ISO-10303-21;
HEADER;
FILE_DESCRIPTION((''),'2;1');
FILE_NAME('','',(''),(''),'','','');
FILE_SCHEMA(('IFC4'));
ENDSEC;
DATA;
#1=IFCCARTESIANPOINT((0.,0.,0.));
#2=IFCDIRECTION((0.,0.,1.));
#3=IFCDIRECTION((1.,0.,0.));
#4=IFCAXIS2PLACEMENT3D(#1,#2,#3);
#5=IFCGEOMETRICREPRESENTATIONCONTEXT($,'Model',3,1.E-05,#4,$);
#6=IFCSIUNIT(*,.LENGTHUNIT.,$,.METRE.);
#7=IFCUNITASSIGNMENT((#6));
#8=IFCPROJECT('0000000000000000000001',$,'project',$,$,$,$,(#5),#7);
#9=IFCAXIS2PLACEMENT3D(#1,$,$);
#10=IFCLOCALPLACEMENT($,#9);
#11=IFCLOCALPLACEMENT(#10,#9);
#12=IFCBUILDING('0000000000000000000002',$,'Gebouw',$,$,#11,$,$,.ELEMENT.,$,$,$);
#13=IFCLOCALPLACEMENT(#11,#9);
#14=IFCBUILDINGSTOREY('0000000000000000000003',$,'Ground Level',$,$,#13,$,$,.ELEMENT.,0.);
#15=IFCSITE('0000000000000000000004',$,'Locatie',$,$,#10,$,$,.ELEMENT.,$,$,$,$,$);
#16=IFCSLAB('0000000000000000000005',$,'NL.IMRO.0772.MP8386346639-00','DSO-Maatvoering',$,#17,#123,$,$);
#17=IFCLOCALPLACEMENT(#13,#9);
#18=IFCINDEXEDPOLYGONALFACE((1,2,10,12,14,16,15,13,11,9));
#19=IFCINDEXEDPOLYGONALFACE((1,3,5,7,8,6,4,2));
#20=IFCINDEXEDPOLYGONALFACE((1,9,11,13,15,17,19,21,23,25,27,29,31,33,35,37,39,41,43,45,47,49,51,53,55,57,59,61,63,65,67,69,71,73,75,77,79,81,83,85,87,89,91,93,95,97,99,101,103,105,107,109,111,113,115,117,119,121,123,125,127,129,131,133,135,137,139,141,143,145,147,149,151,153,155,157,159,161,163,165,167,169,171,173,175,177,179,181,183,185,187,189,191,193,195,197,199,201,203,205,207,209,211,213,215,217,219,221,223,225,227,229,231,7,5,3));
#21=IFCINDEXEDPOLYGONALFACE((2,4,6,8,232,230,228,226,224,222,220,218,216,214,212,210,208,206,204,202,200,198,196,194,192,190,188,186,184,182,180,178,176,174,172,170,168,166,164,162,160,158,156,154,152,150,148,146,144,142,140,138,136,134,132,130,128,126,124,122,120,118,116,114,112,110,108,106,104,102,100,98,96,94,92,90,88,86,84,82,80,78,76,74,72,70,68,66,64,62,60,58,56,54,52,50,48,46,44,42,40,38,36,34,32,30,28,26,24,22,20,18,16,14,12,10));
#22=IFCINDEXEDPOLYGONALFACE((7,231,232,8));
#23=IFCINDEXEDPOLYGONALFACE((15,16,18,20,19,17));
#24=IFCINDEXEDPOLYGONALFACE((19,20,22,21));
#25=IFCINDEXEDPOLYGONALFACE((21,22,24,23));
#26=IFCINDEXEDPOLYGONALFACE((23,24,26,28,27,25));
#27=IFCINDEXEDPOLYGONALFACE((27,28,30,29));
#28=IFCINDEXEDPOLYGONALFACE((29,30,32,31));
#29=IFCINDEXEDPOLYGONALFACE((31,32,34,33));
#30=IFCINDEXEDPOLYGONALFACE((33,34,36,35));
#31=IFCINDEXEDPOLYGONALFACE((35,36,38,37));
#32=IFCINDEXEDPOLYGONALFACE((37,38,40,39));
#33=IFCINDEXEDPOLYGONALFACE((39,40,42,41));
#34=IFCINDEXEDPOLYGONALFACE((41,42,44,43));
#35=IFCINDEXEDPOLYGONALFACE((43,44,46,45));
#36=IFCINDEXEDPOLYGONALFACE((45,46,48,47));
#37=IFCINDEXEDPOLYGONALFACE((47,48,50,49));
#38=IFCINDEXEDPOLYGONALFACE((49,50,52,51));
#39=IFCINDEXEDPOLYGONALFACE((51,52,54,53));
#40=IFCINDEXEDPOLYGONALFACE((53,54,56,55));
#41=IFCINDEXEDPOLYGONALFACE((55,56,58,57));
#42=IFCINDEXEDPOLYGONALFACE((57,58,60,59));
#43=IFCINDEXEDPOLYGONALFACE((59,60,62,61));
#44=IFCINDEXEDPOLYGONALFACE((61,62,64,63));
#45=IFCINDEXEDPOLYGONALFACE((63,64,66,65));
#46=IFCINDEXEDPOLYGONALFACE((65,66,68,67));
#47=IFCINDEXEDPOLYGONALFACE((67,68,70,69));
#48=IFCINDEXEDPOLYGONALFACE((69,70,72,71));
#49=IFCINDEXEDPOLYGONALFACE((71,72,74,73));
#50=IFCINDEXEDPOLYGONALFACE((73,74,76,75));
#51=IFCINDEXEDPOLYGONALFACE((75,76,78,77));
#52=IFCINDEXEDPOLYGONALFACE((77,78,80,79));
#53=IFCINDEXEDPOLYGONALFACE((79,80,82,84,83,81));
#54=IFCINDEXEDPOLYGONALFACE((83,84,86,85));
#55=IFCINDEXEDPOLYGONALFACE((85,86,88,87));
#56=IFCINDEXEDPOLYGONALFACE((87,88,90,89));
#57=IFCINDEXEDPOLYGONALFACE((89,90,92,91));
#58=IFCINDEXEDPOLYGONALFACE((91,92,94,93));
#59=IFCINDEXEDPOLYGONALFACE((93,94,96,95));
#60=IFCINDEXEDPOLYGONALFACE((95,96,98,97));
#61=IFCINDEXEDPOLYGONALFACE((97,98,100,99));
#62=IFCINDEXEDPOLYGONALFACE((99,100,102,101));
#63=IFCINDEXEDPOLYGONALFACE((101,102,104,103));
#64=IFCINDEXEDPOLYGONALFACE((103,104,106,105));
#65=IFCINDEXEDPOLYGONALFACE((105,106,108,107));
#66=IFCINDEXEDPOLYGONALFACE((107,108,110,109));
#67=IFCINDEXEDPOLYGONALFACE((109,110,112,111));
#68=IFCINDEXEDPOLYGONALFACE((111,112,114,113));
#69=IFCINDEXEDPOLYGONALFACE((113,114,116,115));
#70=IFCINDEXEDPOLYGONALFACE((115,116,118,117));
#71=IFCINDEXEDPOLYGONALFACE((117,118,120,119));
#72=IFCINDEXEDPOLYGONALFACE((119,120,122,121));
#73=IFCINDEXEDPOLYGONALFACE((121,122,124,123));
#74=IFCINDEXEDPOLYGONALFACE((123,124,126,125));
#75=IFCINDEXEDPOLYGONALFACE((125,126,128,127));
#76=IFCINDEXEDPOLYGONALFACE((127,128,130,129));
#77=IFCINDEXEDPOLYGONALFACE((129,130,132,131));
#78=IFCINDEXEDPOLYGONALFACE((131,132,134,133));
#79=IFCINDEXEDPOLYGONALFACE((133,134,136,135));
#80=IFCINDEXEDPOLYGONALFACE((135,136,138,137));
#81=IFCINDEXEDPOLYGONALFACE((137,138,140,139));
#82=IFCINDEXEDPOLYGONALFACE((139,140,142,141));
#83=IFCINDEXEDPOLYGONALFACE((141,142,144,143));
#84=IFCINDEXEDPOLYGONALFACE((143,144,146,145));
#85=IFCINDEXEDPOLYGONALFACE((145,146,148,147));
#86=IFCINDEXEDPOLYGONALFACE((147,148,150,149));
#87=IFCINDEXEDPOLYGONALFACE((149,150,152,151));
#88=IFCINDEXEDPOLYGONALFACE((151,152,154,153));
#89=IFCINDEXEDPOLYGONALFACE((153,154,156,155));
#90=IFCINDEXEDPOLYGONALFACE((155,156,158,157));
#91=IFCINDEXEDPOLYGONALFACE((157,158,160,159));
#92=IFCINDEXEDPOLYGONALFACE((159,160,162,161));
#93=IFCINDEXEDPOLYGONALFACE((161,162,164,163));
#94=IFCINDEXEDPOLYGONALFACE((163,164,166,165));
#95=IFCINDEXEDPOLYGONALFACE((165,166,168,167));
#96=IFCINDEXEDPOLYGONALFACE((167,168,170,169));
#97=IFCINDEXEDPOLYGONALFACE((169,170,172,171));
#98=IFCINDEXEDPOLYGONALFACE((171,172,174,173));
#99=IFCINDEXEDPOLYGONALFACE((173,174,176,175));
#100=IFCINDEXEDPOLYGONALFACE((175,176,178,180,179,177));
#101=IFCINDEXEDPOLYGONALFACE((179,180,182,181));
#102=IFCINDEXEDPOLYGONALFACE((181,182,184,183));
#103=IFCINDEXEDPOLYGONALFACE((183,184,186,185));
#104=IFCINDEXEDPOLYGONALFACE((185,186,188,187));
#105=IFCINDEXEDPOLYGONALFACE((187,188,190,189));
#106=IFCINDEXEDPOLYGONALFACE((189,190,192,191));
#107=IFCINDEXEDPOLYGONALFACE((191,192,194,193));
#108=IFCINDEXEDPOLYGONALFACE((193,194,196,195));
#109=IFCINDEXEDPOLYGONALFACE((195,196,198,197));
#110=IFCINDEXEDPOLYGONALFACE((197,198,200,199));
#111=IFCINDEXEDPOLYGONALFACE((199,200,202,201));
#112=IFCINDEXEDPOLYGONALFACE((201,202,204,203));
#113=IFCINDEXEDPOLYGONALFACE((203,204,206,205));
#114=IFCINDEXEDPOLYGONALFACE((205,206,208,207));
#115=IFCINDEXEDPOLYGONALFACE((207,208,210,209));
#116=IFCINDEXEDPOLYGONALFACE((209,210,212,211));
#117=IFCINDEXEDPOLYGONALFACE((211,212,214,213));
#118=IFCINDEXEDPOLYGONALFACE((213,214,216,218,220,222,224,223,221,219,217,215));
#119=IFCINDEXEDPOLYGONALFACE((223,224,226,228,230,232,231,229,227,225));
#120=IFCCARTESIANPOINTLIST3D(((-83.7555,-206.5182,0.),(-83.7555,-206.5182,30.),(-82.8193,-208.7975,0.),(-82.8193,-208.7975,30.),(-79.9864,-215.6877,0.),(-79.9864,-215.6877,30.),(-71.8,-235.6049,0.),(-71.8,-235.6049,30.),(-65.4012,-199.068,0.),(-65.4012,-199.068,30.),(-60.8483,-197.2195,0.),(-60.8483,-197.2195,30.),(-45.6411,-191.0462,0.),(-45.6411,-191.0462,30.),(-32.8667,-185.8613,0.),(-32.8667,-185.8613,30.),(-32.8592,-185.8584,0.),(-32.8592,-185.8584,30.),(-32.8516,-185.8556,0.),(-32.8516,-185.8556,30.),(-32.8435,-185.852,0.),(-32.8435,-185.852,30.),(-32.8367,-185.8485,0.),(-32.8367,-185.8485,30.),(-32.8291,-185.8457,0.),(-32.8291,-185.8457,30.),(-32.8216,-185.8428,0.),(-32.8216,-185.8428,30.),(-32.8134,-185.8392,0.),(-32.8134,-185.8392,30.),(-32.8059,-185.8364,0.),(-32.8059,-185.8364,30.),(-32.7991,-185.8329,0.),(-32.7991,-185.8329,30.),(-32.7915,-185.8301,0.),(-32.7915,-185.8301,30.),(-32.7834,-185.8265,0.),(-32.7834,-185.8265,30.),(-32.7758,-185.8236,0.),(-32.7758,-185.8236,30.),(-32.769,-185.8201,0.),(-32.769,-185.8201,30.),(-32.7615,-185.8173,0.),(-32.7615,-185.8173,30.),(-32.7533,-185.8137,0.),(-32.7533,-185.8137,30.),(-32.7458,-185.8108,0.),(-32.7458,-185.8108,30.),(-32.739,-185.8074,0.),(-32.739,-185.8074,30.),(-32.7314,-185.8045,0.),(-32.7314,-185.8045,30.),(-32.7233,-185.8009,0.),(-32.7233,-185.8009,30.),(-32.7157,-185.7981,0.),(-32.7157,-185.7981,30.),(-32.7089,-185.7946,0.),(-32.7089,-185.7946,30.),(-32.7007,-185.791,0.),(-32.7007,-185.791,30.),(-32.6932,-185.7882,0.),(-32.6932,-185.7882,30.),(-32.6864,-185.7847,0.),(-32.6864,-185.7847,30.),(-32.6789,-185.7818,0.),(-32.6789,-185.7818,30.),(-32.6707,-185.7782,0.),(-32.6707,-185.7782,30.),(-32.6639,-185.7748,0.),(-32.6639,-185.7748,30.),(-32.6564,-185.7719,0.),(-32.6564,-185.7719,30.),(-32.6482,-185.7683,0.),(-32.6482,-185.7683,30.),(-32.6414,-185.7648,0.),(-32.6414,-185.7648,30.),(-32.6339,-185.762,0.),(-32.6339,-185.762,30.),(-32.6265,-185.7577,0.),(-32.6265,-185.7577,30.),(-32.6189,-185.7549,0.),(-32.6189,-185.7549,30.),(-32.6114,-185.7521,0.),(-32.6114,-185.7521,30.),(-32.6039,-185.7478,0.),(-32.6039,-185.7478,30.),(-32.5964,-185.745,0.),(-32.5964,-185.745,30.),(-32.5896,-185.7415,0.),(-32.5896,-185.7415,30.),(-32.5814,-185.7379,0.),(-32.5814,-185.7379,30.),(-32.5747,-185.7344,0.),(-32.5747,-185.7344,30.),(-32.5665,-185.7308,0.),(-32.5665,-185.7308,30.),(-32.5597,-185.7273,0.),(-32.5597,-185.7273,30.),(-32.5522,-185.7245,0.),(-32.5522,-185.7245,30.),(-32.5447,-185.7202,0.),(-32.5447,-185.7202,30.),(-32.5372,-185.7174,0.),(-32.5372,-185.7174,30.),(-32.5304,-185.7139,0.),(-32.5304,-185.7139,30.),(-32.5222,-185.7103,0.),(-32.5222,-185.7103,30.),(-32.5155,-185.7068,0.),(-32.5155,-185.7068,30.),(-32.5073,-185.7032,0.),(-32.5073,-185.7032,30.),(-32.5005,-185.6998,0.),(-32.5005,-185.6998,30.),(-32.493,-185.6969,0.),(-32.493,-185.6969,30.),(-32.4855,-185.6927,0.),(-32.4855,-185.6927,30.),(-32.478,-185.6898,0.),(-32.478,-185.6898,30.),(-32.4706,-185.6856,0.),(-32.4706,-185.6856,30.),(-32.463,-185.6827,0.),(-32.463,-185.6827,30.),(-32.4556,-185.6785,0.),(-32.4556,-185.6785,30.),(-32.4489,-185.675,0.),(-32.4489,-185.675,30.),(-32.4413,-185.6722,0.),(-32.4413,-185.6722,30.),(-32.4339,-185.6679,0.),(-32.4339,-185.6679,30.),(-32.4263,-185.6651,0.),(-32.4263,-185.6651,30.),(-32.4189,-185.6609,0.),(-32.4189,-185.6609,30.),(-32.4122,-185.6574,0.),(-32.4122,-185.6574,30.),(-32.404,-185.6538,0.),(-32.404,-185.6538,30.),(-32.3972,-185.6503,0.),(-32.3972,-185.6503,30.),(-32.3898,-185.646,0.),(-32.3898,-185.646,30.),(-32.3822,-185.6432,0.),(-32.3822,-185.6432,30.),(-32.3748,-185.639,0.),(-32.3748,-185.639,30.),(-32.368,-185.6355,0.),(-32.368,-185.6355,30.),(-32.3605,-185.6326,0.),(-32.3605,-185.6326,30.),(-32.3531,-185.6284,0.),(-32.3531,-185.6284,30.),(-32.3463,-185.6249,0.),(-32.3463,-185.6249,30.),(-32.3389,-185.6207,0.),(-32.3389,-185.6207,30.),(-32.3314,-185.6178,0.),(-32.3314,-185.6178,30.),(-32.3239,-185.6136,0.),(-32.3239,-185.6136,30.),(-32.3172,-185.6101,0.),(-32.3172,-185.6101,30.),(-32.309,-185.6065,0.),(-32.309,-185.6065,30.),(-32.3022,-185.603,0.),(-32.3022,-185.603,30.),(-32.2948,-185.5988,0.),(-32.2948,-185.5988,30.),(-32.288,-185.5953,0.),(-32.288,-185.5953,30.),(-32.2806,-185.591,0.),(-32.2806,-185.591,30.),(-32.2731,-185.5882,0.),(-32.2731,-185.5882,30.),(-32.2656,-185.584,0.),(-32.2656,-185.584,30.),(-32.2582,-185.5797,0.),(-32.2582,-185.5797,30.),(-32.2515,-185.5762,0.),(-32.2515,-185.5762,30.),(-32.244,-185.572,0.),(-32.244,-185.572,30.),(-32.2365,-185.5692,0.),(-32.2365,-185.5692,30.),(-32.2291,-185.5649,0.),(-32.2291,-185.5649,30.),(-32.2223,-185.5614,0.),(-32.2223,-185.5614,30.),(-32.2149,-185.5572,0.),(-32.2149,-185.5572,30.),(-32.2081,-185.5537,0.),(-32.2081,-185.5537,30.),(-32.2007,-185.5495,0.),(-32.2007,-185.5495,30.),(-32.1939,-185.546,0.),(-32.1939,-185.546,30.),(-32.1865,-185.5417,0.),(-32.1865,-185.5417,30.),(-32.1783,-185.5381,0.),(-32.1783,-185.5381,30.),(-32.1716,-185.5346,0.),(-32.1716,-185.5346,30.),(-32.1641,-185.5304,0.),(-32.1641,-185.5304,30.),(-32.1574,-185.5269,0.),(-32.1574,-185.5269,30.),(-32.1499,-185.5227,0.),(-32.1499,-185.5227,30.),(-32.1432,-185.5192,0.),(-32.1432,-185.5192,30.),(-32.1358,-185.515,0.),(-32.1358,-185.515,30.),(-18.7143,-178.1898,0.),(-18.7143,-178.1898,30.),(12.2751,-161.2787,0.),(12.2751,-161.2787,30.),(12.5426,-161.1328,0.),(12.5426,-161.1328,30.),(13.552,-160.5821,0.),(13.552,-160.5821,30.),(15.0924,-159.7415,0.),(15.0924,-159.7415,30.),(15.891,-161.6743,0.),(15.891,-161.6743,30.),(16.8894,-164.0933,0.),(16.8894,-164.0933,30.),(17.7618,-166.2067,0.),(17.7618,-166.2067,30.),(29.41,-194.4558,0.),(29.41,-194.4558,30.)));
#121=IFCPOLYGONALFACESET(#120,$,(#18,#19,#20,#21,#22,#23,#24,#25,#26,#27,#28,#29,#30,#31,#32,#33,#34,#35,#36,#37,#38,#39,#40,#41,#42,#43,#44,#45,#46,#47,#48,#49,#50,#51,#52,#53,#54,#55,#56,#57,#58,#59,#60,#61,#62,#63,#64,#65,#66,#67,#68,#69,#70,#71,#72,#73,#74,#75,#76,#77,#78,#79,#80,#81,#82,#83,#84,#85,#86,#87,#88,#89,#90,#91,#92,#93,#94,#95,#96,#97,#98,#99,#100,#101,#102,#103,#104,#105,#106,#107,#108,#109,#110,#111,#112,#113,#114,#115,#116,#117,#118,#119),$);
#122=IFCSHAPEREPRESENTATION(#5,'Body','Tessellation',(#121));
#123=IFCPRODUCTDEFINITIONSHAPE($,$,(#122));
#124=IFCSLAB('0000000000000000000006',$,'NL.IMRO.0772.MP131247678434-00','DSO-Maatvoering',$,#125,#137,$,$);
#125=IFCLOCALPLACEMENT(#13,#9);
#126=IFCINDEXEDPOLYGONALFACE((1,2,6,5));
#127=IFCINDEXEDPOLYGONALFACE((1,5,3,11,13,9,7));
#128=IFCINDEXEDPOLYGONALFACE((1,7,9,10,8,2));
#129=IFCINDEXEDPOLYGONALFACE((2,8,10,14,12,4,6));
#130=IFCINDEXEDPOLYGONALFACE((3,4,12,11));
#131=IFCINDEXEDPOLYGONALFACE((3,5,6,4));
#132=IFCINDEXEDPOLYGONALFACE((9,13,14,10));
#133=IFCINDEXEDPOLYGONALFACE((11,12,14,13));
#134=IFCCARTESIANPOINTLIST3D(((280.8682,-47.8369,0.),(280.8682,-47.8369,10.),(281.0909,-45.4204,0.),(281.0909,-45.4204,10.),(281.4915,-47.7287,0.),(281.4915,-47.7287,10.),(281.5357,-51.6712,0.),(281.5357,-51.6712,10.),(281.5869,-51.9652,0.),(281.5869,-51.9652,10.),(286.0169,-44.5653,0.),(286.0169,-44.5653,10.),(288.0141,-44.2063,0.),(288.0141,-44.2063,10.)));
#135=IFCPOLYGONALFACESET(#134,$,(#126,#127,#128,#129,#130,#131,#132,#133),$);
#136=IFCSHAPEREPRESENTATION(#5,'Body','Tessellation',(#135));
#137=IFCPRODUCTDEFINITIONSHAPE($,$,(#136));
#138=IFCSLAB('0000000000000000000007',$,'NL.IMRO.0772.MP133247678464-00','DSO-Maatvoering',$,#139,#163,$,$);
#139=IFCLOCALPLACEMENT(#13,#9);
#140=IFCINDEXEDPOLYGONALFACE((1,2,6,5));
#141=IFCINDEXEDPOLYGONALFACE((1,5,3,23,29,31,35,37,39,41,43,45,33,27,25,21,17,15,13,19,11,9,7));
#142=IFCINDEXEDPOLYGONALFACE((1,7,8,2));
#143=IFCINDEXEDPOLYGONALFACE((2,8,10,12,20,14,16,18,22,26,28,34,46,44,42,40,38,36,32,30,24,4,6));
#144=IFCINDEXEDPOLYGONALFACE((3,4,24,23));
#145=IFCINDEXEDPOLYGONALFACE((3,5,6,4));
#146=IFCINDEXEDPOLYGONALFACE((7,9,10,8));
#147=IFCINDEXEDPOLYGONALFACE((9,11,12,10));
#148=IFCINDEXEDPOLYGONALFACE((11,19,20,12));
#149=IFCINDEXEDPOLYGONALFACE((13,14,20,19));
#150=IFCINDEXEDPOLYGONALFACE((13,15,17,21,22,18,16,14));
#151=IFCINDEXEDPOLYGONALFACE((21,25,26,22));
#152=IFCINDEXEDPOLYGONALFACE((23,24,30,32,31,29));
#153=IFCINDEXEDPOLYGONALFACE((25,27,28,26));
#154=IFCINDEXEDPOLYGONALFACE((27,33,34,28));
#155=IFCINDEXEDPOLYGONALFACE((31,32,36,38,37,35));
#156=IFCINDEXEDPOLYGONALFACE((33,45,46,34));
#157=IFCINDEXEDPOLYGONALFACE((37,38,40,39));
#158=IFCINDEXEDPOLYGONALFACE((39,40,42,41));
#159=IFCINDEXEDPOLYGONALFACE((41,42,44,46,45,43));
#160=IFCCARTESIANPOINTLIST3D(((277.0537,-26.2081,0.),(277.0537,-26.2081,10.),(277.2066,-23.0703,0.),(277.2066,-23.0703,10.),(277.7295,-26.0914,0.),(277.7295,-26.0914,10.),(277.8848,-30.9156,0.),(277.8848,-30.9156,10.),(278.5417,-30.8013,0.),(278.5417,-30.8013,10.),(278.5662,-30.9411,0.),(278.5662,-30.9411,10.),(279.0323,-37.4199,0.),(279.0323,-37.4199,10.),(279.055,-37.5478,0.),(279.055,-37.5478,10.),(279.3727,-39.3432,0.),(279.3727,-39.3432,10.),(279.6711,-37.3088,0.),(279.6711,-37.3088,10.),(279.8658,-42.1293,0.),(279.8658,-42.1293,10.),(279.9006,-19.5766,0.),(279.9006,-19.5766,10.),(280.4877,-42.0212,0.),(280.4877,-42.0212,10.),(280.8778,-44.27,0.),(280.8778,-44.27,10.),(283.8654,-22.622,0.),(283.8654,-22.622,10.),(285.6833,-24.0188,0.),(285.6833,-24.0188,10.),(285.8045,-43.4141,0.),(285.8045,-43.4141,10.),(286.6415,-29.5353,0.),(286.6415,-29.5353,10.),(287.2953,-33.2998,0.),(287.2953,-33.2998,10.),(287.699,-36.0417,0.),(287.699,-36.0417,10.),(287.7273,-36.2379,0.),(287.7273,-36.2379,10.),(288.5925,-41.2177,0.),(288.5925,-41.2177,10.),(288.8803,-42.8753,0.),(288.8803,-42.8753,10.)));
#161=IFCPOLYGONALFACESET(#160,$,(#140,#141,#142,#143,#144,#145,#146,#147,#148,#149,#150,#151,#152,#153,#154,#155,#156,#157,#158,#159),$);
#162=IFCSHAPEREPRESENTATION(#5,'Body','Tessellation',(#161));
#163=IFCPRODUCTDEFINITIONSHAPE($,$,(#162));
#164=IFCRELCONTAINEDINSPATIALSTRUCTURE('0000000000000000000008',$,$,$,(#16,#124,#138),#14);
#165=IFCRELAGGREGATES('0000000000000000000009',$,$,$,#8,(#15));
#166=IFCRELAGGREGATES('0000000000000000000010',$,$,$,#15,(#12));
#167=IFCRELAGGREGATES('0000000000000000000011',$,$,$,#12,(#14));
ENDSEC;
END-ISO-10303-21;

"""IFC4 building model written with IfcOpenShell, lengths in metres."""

from ifc_helpers import new_model, si_unit, origin, origin_with_axes, place, context, project, spatial, polyline, outline, extrude, element, save


model = new_model("IFC4")

# Units and contexts
model_context = context("Model", 3, precision=1e-05, world=origin_with_axes())
ifc_project = project(units=[si_unit("LENGTHUNIT", "METRE")], contexts=[model_context])

# Site, building, storey
site_placement = place(None, origin())
site = spatial("IfcSite", under=ifc_project, at=site_placement, Name="Locatie", CompositionType="ELEMENT")
building_placement = place(site_placement, origin())
building = spatial("IfcBuilding", under=site, at=building_placement, Name="Gebouw", CompositionType="ELEMENT")
storey_placement = place(building_placement, origin())
storey = spatial("IfcBuildingStorey", under=building, at=storey_placement, Name="Ground Level", CompositionType="ELEMENT", Elevation=0.0)

# Slabs
slab_1_placement = place(storey_placement, origin())
element("IfcSlab", 1, at=slab_1_placement, inside=storey, Name="NL.IMRO.0772.MP8386346639-00", Description="DSO-Maatvoering", context=model_context, shape_type="SweptSolid", body=[
    extrude(outline(polyline([(-18.7143, -178.1898), (12.2751, -161.2787), (12.5426, -161.1328), (13.552, -160.5821), (15.0924, -159.7415), (15.891, -161.6743), (16.8894, -164.0933), (17.7618, -166.2067), (29.41, -194.4558), (-71.8, -235.6049), (-79.9864, -215.6877), (-82.8193, -208.7975), (-83.7555, -206.5182), (-65.4012, -199.068), (-60.8483, -197.2195), (-45.6411, -191.0462), (-32.8667, -185.8613), (-32.8592, -185.8584), (-32.8516, -185.8556), (-32.8435, -185.852), (-32.8367, -185.8485), (-32.8291, -185.8457), (-32.8216, -185.8428), (-32.8134, -185.8392), (-32.8059, -185.8364), (-32.7991, -185.8329), (-32.7915, -185.8301), (-32.7834, -185.8265), (-32.7758, -185.8236), (-32.769, -185.8201), (-32.7615, -185.8173), (-32.7533, -185.8137), (-32.7458, -185.8108), (-32.739, -185.8074), (-32.7314, -185.8045), (-32.7233, -185.8009), (-32.7157, -185.7981), (-32.7089, -185.7946), (-32.7007, -185.791), (-32.6932, -185.7882), (-32.6864, -185.7847), (-32.6789, -185.7818), (-32.6707, -185.7782), (-32.6639, -185.7748), (-32.6564, -185.7719), (-32.6482, -185.7683), (-32.6414, -185.7648), (-32.6339, -185.762), (-32.6265, -185.7577), (-32.6189, -185.7549), (-32.6114, -185.7521), (-32.6039, -185.7478), (-32.5964, -185.745), (-32.5896, -185.7415), (-32.5814, -185.7379), (-32.5747, -185.7344), (-32.5665, -185.7308), (-32.5597, -185.7273), (-32.5522, -185.7245), (-32.5447, -185.7202), (-32.5372, -185.7174), (-32.5304, -185.7139), (-32.5222, -185.7103), (-32.5155, -185.7068), (-32.5073, -185.7032), (-32.5005, -185.6998), (-32.493, -185.6969), (-32.4855, -185.6927), (-32.478, -185.6898), (-32.4706, -185.6856), (-32.463, -185.6827), (-32.4556, -185.6785), (-32.4489, -185.675), (-32.4413, -185.6722), (-32.4339, -185.6679), (-32.4263, -185.6651), (-32.4189, -185.6609), (-32.4122, -185.6574), (-32.404, -185.6538), (-32.3972, -185.6503), (-32.3898, -185.646), (-32.3822, -185.6432), (-32.3748, -185.639), (-32.368, -185.6355), (-32.3605, -185.6326), (-32.3531, -185.6284), (-32.3463, -185.6249), (-32.3389, -185.6207), (-32.3314, -185.6178), (-32.3239, -185.6136), (-32.3172, -185.6101), (-32.309, -185.6065), (-32.3022, -185.603), (-32.2948, -185.5988), (-32.288, -185.5953), (-32.2806, -185.591), (-32.2731, -185.5882), (-32.2656, -185.584), (-32.2582, -185.5797), (-32.2515, -185.5762), (-32.244, -185.572), (-32.2365, -185.5692), (-32.2291, -185.5649), (-32.2223, -185.5614), (-32.2149, -185.5572), (-32.2081, -185.5537), (-32.2007, -185.5495), (-32.1939, -185.546), (-32.1865, -185.5417), (-32.1783, -185.5381), (-32.1716, -185.5346), (-32.1641, -185.5304), (-32.1574, -185.5269), (-32.1499, -185.5227), (-32.1432, -185.5192), (-32.1358, -185.515), (-18.7143, -178.1898)])), origin_with_axes(), (0.0, 0.0, 1.0), 30.0),
])
slab_2_placement = place(storey_placement, origin())
element("IfcSlab", 2, at=slab_2_placement, inside=storey, Name="NL.IMRO.0772.MP131247678434-00", Description="DSO-Maatvoering", context=model_context, shape_type="SweptSolid", body=[
    extrude(outline(polyline([(281.5357, -51.6712), (280.8682, -47.8369), (281.4915, -47.7287), (281.0909, -45.4204), (286.0169, -44.5653), (288.0141, -44.2063), (281.5869, -51.9652), (281.5357, -51.6712)])), origin_with_axes(), (0.0, 0.0, 1.0), 10.0),
])
slab_3_placement = place(storey_placement, origin())
element("IfcSlab", 3, at=slab_3_placement, inside=storey, Name="NL.IMRO.0772.MP133247678464-00", Description="DSO-Maatvoering", context=model_context, shape_type="SweptSolid", body=[
    extrude(outline(polyline([(287.7273, -36.2379), (288.5925, -41.2177), (288.8803, -42.8753), (285.8045, -43.4141), (280.8778, -44.27), (280.4877, -42.0212), (279.8658, -42.1293), (279.3727, -39.3432), (279.055, -37.5478), (279.0323, -37.4199), (279.6711, -37.3088), (278.5662, -30.9411), (278.5417, -30.8013), (277.8848, -30.9156), (277.0537, -26.2081), (277.7295, -26.0914), (277.2066, -23.0703), (279.9006, -19.5766), (283.8654, -22.622), (285.6833, -24.0188), (286.6415, -29.5353), (287.2953, -33.2998), (287.699, -36.0417), (287.7273, -36.2379)])), origin_with_axes(), (0.0, 0.0, 1.0), 10.0),
])

save(model, "model.ifc")
